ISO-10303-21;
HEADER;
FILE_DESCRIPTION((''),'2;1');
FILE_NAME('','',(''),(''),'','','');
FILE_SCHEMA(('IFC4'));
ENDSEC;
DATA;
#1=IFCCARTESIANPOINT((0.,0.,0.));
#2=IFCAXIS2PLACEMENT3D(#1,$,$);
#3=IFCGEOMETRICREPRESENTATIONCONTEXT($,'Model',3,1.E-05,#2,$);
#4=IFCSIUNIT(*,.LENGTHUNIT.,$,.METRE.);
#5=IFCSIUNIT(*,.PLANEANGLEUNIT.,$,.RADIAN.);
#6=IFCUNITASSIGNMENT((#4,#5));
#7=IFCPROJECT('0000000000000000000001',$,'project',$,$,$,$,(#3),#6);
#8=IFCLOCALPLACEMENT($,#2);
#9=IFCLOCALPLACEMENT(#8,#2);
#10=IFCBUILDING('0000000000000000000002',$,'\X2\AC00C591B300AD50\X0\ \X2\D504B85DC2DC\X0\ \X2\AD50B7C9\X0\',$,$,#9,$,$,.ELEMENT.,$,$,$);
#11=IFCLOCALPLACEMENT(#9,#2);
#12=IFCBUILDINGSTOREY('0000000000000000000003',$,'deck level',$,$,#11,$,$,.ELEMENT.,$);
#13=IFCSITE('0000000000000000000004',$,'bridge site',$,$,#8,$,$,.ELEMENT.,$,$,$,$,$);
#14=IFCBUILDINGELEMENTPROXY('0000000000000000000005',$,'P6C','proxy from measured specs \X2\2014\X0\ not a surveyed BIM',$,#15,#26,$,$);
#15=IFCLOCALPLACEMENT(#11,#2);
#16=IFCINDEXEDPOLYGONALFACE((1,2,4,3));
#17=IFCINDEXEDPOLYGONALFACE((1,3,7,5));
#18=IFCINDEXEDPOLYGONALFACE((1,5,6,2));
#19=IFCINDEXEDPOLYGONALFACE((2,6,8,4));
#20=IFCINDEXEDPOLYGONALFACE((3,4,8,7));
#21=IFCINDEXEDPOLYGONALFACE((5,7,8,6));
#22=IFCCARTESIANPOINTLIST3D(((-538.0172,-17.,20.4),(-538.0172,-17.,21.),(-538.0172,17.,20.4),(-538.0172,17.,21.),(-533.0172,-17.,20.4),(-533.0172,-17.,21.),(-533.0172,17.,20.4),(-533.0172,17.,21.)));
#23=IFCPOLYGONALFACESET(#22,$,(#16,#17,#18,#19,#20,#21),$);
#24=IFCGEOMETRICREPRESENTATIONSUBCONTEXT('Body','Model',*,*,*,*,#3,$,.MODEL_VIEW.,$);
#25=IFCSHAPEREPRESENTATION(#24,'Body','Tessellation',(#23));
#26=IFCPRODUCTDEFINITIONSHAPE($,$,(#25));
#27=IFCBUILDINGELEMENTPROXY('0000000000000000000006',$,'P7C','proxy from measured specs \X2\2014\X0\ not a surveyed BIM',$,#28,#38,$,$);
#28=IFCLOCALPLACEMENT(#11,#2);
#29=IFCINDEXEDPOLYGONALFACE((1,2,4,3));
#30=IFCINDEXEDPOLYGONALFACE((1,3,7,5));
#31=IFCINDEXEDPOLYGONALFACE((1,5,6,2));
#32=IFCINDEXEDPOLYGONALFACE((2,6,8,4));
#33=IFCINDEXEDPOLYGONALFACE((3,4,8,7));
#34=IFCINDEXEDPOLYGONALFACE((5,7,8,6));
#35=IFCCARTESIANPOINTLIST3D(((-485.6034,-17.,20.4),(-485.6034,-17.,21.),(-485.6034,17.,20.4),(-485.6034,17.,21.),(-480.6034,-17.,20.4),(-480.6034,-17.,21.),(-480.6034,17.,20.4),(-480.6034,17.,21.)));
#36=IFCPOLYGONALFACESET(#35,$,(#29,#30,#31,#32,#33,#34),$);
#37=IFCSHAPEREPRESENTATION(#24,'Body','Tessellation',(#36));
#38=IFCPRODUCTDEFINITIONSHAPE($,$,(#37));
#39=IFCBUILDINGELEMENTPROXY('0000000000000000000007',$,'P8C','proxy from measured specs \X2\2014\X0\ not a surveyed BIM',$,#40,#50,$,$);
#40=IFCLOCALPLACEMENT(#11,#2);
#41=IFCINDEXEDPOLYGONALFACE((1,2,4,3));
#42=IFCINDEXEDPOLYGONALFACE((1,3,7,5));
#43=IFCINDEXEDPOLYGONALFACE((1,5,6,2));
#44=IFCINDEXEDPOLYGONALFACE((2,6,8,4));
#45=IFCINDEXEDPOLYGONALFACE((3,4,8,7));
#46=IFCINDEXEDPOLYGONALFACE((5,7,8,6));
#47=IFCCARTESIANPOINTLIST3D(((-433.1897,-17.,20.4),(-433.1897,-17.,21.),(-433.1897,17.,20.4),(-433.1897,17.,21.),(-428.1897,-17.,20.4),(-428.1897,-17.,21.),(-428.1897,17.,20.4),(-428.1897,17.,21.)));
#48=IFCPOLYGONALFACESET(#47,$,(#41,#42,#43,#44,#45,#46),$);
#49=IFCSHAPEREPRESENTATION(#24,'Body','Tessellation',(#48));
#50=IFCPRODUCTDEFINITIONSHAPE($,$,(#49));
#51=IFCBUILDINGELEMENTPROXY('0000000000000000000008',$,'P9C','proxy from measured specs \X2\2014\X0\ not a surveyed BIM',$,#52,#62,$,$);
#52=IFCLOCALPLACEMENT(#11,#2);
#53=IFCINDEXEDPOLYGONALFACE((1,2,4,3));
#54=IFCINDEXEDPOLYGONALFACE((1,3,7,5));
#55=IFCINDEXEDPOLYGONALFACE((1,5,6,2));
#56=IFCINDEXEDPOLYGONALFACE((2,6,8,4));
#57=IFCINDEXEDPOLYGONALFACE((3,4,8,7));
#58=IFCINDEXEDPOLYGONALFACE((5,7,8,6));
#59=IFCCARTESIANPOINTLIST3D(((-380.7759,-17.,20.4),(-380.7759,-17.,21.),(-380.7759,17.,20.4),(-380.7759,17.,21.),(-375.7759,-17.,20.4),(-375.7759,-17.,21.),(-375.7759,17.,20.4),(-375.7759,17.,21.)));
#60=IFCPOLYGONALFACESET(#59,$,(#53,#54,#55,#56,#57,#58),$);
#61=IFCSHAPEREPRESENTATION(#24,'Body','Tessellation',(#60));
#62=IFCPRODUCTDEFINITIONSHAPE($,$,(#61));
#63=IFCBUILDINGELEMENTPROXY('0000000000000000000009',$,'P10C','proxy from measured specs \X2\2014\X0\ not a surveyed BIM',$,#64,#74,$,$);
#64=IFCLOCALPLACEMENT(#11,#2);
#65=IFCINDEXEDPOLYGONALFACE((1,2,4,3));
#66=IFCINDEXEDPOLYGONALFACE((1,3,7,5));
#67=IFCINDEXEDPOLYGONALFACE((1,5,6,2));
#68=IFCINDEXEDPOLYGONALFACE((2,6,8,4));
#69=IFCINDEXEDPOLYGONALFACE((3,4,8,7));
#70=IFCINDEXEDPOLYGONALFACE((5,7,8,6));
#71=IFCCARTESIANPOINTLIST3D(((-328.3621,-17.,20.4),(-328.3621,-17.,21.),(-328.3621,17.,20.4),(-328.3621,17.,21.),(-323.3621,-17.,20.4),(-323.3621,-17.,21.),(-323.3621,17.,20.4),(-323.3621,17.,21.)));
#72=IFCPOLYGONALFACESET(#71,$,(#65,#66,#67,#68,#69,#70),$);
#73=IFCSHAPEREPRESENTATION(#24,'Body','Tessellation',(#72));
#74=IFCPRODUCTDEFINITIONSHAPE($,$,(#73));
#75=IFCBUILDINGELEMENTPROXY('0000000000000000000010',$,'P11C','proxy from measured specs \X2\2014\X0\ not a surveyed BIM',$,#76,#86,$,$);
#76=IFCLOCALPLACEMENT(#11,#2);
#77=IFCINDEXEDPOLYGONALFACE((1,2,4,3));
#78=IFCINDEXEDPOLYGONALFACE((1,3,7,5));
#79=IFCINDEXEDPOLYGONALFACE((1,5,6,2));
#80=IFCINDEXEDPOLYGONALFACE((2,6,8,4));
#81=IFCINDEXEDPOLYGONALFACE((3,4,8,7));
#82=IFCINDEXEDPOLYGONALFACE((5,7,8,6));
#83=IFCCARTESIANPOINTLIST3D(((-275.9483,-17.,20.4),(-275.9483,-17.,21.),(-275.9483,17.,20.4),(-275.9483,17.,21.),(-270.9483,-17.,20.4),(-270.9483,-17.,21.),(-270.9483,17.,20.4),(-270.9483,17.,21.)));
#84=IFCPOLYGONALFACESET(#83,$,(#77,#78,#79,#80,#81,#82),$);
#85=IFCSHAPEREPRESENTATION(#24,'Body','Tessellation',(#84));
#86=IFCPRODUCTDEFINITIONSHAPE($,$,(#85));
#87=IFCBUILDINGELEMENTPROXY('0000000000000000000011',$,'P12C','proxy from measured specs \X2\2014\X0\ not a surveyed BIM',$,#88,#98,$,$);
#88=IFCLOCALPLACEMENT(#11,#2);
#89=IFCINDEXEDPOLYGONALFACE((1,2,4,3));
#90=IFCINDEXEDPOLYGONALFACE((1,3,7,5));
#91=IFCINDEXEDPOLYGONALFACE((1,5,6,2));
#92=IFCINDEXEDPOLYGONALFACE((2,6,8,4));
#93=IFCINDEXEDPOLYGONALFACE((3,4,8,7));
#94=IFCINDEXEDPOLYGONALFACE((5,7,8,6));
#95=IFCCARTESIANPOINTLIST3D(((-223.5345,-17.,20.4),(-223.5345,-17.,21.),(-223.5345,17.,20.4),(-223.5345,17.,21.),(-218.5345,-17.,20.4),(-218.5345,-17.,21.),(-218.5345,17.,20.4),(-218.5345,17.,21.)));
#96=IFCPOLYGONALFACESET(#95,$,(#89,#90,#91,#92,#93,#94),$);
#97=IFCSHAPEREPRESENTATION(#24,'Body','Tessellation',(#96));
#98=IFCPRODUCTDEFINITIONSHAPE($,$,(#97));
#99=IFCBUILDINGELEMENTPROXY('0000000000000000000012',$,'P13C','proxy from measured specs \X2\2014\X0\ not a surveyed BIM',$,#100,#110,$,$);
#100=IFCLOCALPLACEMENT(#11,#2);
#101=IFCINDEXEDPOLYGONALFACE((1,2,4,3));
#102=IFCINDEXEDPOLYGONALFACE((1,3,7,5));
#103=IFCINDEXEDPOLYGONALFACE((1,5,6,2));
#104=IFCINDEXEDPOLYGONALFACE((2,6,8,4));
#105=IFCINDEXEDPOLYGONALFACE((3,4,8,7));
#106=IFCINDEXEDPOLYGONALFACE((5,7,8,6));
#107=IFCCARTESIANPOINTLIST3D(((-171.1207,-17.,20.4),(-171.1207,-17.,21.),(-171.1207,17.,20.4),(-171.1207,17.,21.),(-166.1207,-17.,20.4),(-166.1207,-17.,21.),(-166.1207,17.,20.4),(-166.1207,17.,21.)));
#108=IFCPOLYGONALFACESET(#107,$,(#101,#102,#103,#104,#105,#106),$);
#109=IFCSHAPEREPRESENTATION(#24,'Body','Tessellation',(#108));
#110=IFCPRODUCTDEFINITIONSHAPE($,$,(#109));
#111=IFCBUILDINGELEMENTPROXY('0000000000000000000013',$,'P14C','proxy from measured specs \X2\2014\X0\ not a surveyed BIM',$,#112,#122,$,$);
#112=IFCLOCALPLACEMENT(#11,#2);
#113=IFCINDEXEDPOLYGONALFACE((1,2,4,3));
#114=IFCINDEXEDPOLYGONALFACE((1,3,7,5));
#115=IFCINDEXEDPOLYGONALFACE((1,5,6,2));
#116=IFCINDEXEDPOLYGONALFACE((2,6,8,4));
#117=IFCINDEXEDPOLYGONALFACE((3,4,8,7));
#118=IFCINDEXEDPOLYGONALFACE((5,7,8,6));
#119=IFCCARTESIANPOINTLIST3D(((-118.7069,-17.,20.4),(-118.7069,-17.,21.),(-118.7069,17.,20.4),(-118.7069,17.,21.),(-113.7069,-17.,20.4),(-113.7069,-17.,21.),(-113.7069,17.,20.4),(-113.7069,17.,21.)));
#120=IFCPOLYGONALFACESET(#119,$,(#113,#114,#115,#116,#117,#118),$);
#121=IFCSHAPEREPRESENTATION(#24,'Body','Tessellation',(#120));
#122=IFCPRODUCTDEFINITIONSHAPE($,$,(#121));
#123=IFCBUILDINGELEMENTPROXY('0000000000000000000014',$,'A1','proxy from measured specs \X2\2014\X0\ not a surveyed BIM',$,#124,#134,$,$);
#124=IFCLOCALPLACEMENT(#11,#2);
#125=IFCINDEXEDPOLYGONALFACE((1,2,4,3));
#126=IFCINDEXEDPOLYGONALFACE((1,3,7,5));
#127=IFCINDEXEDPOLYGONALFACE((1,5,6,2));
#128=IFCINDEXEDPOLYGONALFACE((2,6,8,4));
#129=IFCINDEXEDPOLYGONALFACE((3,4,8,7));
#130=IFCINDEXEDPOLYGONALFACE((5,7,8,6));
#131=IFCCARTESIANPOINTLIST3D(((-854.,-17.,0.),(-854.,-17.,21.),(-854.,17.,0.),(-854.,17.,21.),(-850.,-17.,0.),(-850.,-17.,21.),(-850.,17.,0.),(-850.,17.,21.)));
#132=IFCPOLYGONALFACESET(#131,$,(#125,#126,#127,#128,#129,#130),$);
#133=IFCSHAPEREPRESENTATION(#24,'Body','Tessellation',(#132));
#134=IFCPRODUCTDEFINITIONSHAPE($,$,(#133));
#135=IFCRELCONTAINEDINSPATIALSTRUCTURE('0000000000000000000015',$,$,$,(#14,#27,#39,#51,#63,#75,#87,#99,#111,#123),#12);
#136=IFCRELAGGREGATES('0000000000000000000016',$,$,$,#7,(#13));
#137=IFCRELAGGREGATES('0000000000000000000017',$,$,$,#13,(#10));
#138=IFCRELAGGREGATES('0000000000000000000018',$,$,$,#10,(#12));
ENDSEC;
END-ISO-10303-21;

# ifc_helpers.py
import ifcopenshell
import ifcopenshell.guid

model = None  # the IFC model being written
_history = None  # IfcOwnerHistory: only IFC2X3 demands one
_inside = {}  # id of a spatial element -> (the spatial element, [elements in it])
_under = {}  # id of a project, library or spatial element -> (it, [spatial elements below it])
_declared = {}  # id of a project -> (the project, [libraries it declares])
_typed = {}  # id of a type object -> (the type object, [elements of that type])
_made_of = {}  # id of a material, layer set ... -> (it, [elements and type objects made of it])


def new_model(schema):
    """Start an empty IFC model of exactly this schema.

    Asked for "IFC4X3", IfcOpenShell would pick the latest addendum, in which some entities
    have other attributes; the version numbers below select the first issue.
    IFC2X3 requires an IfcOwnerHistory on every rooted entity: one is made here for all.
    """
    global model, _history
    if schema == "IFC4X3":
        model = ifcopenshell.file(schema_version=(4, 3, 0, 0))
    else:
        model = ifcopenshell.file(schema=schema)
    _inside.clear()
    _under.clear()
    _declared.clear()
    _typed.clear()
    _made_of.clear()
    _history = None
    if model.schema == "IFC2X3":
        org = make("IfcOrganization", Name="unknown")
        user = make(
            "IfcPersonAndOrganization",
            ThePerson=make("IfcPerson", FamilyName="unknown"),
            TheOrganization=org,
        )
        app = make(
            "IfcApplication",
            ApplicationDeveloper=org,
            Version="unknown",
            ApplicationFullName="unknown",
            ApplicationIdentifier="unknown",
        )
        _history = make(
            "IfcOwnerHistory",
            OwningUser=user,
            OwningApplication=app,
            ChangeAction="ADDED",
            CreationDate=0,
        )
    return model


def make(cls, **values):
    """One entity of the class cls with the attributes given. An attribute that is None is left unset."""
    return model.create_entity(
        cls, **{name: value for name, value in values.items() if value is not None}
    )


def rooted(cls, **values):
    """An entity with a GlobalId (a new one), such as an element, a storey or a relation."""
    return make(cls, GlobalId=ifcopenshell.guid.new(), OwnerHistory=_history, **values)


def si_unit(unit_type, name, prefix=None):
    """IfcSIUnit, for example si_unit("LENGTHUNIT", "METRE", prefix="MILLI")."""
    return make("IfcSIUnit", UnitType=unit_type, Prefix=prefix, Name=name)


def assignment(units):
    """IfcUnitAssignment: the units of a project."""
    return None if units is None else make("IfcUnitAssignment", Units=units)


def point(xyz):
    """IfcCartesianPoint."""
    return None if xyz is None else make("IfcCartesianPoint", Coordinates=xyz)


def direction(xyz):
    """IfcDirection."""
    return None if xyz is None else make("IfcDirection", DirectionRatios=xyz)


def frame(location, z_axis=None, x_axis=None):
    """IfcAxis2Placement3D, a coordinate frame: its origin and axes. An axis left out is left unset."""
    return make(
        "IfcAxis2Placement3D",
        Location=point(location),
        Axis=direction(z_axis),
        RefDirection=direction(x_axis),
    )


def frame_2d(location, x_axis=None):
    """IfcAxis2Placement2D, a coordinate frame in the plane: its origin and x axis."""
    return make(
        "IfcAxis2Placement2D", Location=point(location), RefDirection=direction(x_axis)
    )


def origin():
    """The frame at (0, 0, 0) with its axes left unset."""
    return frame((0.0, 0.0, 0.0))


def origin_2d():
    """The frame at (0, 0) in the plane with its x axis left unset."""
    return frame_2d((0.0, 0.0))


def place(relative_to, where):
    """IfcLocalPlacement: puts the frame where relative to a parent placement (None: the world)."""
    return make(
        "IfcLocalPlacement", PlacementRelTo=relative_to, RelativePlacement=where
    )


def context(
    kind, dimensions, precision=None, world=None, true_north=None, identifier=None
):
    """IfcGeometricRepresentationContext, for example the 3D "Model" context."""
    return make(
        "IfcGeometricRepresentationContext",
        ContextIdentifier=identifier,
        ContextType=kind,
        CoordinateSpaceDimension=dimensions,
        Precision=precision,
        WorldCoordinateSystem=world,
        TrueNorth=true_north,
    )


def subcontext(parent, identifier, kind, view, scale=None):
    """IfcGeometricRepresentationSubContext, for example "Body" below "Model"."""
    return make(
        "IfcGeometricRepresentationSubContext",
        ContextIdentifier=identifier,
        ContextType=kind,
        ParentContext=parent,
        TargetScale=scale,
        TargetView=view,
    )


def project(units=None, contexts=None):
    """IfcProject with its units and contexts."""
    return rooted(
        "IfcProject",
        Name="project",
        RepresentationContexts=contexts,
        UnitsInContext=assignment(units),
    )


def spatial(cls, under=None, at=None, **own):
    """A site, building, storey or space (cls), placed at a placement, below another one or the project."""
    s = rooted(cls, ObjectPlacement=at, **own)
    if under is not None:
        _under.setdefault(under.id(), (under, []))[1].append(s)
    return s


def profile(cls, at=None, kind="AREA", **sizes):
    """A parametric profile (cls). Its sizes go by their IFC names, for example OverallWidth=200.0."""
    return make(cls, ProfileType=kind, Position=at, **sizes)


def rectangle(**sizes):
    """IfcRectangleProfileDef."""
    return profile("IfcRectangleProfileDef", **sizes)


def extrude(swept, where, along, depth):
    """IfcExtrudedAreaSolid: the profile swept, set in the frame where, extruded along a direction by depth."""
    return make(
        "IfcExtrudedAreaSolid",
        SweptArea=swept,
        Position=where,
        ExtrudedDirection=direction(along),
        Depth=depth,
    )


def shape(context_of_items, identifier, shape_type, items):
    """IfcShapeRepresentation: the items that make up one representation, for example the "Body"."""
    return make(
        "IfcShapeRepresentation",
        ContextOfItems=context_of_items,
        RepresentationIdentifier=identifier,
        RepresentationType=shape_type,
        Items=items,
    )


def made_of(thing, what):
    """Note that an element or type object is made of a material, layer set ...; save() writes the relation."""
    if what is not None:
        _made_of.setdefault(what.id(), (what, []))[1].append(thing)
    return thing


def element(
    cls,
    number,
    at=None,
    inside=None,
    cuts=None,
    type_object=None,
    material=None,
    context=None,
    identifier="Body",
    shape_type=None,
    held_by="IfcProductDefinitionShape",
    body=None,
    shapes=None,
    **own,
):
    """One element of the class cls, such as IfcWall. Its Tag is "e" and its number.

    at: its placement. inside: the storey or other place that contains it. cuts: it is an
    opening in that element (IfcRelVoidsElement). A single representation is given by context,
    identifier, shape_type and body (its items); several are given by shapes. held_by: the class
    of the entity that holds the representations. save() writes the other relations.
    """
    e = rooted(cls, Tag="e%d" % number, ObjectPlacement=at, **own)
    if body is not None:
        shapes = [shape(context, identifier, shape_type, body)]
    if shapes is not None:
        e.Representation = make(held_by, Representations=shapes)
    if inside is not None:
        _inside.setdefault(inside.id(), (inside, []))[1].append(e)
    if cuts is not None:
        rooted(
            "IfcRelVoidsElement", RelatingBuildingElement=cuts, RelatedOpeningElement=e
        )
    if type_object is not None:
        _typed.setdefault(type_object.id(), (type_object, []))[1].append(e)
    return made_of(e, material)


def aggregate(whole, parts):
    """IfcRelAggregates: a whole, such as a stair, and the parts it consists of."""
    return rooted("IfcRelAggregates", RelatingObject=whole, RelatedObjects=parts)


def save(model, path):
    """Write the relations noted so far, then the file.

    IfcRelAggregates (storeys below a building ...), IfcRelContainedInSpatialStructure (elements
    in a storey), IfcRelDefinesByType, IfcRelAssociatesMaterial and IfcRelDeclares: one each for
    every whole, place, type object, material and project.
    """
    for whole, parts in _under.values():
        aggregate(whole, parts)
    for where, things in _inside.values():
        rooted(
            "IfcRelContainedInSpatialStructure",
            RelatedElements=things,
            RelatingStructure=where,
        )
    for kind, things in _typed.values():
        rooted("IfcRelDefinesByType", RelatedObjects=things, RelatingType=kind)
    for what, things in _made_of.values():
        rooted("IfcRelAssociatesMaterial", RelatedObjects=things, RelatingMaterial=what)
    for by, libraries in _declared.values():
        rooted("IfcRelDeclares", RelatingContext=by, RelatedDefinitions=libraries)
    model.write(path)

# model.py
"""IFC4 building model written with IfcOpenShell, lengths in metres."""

from ifc_helpers import new_model, si_unit, frame, origin, origin_2d, place, context, subcontext, project, spatial, rectangle, extrude, element, save


model = new_model("IFC4")

# Units and contexts
model_context = context("Model", 3, precision=1e-05, world=origin())
body_context = subcontext(model_context, "Body", "Model", "MODEL_VIEW")
ifc_project = project(units=[si_unit("LENGTHUNIT", "METRE"), si_unit("PLANEANGLEUNIT", "RADIAN")], contexts=[model_context])

# Site, building, storey
site_placement = place(None, origin())
site = spatial("IfcSite", under=ifc_project, at=site_placement, Name="bridge site", CompositionType="ELEMENT")
building_placement = place(site_placement, origin())
building = spatial("IfcBuilding", under=site, at=building_placement, Name="가양대교 프록시 교량", CompositionType="ELEMENT")
storey_placement = place(building_placement, origin())
storey = spatial("IfcBuildingStorey", under=building, at=storey_placement, Name="deck level", CompositionType="ELEMENT")

# Building element proxies
for number, where, name in (
    (1, (-535.5172, 0.0, 20.4), "P6C"),
    (2, (-483.1034, 0.0, 20.4), "P7C"),
    (3, (-430.6897, 0.0, 20.4), "P8C"),
    (4, (-378.2759, 0.0, 20.4), "P9C"),
    (5, (-325.8621, 0.0, 20.4), "P10C"),
    (6, (-273.4483, 0.0, 20.4), "P11C"),
    (7, (-221.0345, 0.0, 20.4), "P12C"),
    (8, (-168.6207, 0.0, 20.4), "P13C"),
    (9, (-116.2069, 0.0, 20.4), "P14C"),
):
    element("IfcBuildingElementProxy", number, at=place(storey_placement, frame(where)), inside=storey, Name=name, Description="proxy from measured specs — not a surveyed BIM", context=body_context, shape_type="SweptSolid", body=[
        extrude(rectangle(XDim=5.0, YDim=34.0, at=origin_2d()), origin(), (0.0, 0.0, 1.0), 0.6),
    ])
proxy_placement = place(storey_placement, frame((-852.0, 0.0, 0.0)))
element("IfcBuildingElementProxy", 10, at=proxy_placement, inside=storey, Name="A1", Description="proxy from measured specs — not a surveyed BIM", context=body_context, shape_type="SweptSolid", body=[
    extrude(rectangle(XDim=4.0, YDim=34.0, at=origin_2d()), origin(), (0.0, 0.0, 1.0), 21.0),
])

save(model, "model.ifc")
